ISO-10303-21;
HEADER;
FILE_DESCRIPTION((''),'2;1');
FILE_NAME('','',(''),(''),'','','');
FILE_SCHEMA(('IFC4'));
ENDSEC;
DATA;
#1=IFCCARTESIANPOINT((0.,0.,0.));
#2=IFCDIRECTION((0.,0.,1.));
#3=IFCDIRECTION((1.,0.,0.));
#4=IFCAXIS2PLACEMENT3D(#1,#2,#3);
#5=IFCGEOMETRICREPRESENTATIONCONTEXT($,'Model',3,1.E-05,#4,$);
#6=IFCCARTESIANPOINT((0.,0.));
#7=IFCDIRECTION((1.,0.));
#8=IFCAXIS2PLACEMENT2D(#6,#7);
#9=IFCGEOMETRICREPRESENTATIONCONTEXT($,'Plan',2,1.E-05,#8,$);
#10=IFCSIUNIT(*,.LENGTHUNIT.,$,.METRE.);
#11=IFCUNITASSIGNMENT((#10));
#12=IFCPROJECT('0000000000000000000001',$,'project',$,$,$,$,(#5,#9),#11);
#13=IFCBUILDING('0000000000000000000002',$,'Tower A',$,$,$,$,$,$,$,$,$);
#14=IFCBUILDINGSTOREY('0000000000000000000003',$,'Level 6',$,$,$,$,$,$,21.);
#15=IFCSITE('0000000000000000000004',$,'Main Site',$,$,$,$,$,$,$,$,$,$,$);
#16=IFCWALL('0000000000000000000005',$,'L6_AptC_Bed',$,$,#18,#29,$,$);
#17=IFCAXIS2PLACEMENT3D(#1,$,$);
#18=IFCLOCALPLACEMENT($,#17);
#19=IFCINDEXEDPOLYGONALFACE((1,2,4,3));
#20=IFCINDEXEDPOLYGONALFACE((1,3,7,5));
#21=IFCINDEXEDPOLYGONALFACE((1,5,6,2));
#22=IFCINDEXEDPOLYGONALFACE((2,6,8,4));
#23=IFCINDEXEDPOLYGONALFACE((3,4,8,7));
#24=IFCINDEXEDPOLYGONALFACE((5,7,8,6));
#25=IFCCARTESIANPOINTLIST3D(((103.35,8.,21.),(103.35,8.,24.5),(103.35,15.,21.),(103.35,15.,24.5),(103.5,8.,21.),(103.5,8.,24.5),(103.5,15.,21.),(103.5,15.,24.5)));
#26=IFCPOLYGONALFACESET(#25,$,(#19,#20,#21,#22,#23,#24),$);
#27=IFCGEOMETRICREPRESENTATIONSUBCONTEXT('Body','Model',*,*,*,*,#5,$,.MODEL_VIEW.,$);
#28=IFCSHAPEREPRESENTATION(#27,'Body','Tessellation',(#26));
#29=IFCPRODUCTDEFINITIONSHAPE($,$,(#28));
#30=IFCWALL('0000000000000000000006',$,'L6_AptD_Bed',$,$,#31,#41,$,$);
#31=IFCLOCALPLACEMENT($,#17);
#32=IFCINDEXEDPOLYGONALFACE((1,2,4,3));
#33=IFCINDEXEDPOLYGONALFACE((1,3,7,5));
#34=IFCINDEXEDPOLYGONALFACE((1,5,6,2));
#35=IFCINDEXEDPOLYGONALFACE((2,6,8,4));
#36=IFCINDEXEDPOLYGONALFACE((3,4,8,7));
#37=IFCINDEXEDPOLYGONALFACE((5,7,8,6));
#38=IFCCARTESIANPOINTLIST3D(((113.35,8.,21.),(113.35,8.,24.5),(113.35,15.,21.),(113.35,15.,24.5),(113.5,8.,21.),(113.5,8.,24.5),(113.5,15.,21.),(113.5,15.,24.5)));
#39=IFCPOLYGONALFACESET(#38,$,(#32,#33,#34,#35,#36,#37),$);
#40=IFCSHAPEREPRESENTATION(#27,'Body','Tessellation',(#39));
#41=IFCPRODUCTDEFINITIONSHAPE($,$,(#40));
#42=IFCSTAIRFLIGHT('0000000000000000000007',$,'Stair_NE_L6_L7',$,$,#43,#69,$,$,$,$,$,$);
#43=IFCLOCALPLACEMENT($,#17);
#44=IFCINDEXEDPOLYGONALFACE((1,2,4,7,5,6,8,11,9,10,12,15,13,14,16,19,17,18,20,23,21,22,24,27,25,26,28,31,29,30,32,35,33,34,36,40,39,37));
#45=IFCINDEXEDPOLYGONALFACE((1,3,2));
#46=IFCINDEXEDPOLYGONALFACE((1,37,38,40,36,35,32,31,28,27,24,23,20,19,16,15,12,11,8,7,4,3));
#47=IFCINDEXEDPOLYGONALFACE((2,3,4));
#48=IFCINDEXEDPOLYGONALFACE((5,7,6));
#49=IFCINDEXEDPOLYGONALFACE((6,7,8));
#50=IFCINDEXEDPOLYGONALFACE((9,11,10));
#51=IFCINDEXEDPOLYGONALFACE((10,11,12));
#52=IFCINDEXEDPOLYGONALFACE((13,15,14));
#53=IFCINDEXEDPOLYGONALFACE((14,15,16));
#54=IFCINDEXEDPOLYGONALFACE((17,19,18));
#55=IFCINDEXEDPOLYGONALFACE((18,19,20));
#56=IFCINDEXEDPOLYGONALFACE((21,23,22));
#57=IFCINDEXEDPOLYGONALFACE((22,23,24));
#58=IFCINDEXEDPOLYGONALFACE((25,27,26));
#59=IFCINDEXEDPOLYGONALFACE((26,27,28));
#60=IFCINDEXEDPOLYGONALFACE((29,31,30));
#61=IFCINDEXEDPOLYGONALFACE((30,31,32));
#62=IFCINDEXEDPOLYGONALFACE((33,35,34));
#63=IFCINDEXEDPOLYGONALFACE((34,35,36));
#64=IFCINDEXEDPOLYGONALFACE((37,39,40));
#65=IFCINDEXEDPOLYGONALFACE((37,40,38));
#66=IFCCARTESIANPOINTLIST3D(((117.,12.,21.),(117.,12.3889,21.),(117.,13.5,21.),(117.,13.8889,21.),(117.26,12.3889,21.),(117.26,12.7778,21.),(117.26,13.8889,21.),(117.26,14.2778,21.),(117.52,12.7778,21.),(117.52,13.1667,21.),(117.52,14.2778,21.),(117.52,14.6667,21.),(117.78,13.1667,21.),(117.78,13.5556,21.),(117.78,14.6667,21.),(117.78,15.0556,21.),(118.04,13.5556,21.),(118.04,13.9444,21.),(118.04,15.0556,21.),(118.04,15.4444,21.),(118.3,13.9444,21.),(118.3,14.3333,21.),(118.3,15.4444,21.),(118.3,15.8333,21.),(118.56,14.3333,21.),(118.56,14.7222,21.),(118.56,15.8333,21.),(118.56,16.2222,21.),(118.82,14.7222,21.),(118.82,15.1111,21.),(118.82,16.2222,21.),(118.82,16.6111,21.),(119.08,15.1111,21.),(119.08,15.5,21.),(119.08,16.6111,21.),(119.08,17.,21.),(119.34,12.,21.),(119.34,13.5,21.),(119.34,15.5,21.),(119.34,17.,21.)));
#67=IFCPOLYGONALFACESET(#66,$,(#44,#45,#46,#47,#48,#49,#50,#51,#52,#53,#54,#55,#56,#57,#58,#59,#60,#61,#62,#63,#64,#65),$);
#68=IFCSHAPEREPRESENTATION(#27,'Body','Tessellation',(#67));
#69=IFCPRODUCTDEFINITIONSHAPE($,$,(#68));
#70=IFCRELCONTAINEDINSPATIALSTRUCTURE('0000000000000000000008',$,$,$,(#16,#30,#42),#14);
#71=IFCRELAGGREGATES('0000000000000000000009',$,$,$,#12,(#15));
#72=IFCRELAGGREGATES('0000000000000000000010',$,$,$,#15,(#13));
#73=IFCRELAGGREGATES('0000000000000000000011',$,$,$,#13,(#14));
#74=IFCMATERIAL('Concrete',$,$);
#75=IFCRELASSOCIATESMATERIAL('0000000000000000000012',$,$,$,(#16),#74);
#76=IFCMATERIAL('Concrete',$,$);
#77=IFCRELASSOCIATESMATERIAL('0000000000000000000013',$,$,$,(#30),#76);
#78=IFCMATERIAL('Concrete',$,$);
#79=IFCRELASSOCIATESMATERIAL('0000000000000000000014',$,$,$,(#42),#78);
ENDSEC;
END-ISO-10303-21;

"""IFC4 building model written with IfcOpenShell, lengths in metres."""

from ifc_helpers import new_model, si_unit, frame, origin_with_axes, origin_2d_with_axis, place, context, subcontext, project, spatial, line, indexed_curve, outline, extrude, material, element, save


model = new_model("IFC4")

# Units and contexts
model_context = context("Model", 3, precision=1e-05, world=origin_with_axes())
plan_context = context("Plan", 2, precision=1e-05, world=origin_2d_with_axis())
body_context = subcontext(model_context, "Body", "Model", "MODEL_VIEW")
ifc_project = project(units=[si_unit("LENGTHUNIT", "METRE")], contexts=[model_context, plan_context])

# Site, building, storey
site = spatial("IfcSite", under=ifc_project, Name="Main Site")
building = spatial("IfcBuilding", under=site, Name="Tower A")
storey = spatial("IfcBuildingStorey", under=building, Name="Level 6", Elevation=21.0)

# Walls
ifc_material_1 = material(Name="Concrete")
wall_1_placement = place(None, frame((103.5, 8.0, 21.0), z_axis=(0.0, 0.0, 1.0), x_axis=(0.0, 1.0, 0.0)))
element("IfcWall", 1, at=wall_1_placement, inside=storey, material=ifc_material_1, Name="L6_AptC_Bed", context=body_context, shape_type="SweptSolid", body=[
    extrude(outline(indexed_curve([(0.0, 0.0), (0.0, 0.15), (7.0, 0.15), (7.0, 0.0), (0.0, 0.0)], self_intersect=False)), origin_with_axes(), (0.0, 0.0, 1.0), 3.5),
])
ifc_material_2 = material(Name="Concrete")
wall_2_placement = place(None, frame((113.5, 8.0, 21.0), z_axis=(0.0, 0.0, 1.0), x_axis=(0.0, 1.0, 0.0)))
element("IfcWall", 2, at=wall_2_placement, inside=storey, material=ifc_material_2, Name="L6_AptD_Bed", context=body_context, shape_type="SweptSolid", body=[
    extrude(outline(indexed_curve([(0.0, 0.0), (0.0, 0.15), (7.0, 0.15), (7.0, 0.0), (0.0, 0.0)], self_intersect=False)), origin_with_axes(), (0.0, 0.0, 1.0), 3.5),
])

# Stair flight
ifc_material_3 = material(Name="Concrete")
stair_flight_placement = place(None, frame((117.0, 12.0, 21.0), z_axis=(0.0, 0.0, 1.0), x_axis=(1.0, 0.0, 0.0)))
element("IfcStairFlight", 3, at=stair_flight_placement, inside=storey, material=ifc_material_3, Name="Stair_NE_L6_L7", context=body_context, shape_type="SweptSolid", body=[
    extrude(outline(indexed_curve([(0.0, 0.0), (0.0, 0.3889), (0.26, 0.3889), (0.26, 0.7778), (0.52, 0.7778), (0.52, 1.1667), (0.78, 1.1667), (0.78, 1.5556), (1.04, 1.5556), (1.04, 1.9444), (1.3, 1.9444), (1.3, 2.3333), (1.56, 2.3333), (1.56, 2.7222), (1.82, 2.7222), (1.82, 3.1111), (2.08, 3.1111), (2.08, 3.5), (2.34, 3.5), (2.34, 0.0)], segments=[line(1, 2, 3, 4, 5, 6, 7, 8, 9, 10, 11, 12, 13, 14, 15, 16, 17, 18, 19, 20, 1)])), origin_with_axes(), (0.0, 1.0, 0.0), 1.5),
])

save(model, "model.ifc")
